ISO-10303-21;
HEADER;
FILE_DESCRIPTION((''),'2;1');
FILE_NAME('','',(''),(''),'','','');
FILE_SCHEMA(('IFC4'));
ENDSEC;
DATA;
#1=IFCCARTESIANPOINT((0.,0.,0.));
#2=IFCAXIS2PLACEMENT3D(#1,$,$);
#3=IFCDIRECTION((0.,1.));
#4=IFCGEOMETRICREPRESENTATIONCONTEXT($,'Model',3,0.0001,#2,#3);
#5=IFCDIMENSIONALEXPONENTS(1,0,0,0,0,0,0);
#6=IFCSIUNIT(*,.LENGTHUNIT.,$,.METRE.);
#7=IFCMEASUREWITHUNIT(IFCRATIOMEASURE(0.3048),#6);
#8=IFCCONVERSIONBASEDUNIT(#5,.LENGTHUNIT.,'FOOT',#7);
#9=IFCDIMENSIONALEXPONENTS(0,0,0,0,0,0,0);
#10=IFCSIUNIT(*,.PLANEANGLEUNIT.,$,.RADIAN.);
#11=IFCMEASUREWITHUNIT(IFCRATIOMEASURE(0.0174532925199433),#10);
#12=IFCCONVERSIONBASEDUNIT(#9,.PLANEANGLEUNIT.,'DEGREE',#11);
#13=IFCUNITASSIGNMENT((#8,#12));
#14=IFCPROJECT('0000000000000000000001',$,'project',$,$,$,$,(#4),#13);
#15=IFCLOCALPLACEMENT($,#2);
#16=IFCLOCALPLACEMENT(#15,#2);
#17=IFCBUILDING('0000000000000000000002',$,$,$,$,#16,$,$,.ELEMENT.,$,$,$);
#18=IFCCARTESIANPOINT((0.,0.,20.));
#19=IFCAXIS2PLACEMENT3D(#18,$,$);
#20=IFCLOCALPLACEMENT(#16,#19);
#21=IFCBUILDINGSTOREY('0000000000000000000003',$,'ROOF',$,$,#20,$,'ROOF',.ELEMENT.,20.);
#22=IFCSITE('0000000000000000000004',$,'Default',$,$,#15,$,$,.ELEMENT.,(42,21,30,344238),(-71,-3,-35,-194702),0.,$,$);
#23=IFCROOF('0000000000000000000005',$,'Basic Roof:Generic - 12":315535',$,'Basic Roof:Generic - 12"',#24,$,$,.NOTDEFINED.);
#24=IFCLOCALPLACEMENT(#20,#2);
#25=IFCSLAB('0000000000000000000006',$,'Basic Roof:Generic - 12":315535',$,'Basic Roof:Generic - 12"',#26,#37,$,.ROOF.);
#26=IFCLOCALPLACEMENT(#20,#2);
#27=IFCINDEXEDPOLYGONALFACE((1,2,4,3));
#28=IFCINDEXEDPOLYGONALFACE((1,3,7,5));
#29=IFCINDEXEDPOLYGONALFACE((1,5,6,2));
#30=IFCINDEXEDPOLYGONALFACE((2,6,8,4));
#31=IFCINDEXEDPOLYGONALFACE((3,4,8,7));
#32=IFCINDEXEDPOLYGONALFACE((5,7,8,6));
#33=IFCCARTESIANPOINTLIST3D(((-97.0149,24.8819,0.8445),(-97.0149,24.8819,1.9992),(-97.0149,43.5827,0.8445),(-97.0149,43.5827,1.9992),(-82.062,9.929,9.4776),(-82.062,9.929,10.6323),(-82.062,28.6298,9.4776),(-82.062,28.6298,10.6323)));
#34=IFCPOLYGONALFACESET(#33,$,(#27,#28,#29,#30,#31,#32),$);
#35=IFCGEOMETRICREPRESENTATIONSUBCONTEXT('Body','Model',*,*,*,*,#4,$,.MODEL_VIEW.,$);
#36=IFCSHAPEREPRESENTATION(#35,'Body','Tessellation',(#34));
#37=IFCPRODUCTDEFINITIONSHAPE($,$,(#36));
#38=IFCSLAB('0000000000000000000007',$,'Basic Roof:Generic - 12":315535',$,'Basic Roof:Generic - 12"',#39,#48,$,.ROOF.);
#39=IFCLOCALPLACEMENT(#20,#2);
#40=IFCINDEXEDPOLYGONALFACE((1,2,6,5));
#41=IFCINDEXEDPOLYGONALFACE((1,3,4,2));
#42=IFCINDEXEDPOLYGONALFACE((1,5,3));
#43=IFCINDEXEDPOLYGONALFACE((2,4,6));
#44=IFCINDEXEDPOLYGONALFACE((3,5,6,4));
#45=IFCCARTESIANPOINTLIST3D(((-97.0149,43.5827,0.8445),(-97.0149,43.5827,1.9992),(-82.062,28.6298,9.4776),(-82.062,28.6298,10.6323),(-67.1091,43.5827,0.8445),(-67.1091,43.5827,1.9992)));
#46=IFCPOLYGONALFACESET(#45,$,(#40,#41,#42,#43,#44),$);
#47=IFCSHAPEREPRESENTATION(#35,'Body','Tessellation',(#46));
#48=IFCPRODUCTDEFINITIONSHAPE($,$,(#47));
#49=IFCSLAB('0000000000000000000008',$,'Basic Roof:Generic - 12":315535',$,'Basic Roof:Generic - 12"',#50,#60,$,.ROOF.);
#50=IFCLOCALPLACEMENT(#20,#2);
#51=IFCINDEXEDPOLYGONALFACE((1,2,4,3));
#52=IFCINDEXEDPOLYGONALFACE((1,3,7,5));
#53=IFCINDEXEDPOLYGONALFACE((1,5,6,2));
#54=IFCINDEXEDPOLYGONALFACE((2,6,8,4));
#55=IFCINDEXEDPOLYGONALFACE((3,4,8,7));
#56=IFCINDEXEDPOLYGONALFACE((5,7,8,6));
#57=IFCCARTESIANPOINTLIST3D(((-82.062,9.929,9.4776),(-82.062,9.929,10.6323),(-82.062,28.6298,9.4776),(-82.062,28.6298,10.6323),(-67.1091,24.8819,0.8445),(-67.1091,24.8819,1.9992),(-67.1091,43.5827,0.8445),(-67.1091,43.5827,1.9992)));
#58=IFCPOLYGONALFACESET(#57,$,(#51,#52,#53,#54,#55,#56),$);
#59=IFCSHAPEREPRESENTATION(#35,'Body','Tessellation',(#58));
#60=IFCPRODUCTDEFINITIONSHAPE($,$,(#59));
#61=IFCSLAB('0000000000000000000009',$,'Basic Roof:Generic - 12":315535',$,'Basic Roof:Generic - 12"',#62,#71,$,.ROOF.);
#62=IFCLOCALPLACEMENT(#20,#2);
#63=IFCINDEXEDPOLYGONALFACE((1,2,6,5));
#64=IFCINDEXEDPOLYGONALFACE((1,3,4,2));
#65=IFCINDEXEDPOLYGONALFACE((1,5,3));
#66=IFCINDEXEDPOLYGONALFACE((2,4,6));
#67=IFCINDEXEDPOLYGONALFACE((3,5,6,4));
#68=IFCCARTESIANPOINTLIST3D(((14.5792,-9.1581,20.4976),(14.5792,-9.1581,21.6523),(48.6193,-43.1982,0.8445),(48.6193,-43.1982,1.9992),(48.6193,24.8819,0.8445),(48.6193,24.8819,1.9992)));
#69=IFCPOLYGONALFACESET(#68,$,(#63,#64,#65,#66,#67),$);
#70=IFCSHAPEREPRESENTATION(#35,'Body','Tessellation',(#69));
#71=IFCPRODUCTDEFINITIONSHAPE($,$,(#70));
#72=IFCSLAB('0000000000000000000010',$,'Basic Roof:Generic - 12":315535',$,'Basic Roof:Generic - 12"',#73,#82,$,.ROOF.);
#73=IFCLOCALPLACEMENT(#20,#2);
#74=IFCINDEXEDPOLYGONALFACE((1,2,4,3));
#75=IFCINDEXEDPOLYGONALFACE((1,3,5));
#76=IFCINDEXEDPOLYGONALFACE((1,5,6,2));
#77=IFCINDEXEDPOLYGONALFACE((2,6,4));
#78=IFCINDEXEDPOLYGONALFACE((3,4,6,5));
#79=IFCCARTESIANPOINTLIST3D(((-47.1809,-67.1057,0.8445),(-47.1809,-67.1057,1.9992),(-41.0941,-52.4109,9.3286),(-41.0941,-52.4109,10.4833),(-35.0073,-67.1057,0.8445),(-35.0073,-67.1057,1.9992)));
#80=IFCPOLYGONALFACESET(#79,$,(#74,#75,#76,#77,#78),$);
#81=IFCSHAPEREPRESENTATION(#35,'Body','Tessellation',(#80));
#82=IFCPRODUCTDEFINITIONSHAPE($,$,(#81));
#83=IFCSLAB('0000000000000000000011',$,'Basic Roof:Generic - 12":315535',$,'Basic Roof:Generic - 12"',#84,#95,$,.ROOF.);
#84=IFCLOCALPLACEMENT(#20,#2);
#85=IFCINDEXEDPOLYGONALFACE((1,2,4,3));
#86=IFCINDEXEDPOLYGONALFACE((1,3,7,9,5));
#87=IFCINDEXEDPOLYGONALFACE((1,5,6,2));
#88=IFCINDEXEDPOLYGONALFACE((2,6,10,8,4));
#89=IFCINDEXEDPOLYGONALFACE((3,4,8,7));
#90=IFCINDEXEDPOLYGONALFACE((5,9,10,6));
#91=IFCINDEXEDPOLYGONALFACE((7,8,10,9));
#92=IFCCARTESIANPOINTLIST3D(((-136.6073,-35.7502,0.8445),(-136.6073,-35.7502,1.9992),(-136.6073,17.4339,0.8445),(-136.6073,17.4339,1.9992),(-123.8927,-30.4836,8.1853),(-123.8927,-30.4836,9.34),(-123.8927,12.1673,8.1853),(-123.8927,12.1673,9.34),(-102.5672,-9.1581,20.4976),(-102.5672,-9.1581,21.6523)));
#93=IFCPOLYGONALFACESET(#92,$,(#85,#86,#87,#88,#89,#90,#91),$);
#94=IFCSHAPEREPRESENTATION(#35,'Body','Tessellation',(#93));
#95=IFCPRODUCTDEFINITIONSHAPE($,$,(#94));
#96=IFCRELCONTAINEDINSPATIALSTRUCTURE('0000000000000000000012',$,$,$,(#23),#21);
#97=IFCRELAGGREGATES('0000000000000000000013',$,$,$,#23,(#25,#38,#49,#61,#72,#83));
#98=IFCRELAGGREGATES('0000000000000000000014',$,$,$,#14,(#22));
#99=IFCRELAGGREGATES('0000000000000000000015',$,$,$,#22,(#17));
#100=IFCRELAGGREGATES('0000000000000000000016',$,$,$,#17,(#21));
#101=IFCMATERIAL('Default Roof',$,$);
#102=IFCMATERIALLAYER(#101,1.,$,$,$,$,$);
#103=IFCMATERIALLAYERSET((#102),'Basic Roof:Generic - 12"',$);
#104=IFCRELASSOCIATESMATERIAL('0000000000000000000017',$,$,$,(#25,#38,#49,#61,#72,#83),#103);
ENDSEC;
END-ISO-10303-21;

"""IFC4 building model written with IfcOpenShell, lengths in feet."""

from ifc_helpers import new_model, entity, si_unit, converted_unit, direction, frame, origin, place, context, subcontext, project, spatial, polyline, outline, extrude, material, layer, layer_set, element, aggregate, save


model = new_model("IFC4")

# Units and contexts
model_context = context("Model", 3, precision=0.0001, world=origin(), true_north=direction((0.0, 1.0)))
body_context = subcontext(model_context, "Body", "Model", "MODEL_VIEW")
ifc_project = project(units=[converted_unit("LENGTHUNIT", "FOOT", entity("IfcRatioMeasure", 0.3048), si_unit("LENGTHUNIT", "METRE"), dimensions=[1, 0, 0, 0, 0, 0, 0]), converted_unit("PLANEANGLEUNIT", "DEGREE", entity("IfcRatioMeasure", 0.0174532925199433), si_unit("PLANEANGLEUNIT", "RADIAN"), dimensions=[0, 0, 0, 0, 0, 0, 0])], contexts=[model_context])

# Site, building, storey
site_placement = place(None, origin())
site = spatial("IfcSite", under=ifc_project, at=site_placement, Name="Default", CompositionType="ELEMENT", RefLatitude=(42, 21, 30, 344238), RefLongitude=(-71, -3, -35, -194702), RefElevation=0.0)
building_placement = place(site_placement, origin())
building = spatial("IfcBuilding", under=site, at=building_placement, CompositionType="ELEMENT")
storey_placement = place(building_placement, frame((0.0, 0.0, 20.0)))
storey = spatial("IfcBuildingStorey", under=building, at=storey_placement, Name="ROOF", LongName="ROOF", CompositionType="ELEMENT", Elevation=20.0)

# Roof, slabs
roof_placement = place(storey_placement, frame((-136.6073, -67.1057, 0.8445)))
roof = element("IfcRoof", 1, at=roof_placement, inside=storey, Name="Basic Roof:Generic - 12\":315535", ObjectType="Basic Roof:Generic - 12\"", PredefinedType="NOTDEFINED")
ifc_material = material(Name="Default Roof")
ifc_layer = layer(ifc_material, 1.0)
ifc_layer_set = layer_set([ifc_layer], Name="Basic Roof:Generic - 12\"")
slab_1_placement = place(roof_placement, origin())
slab_1 = element("IfcSlab", 2, at=slab_1_placement, material=ifc_layer_set, Name="Basic Roof:Generic - 12\":315535", ObjectType="Basic Roof:Generic - 12\"", PredefinedType="ROOF", context=body_context, shape_type="SweptSolid", body=[
    extrude(outline(polyline([(-8.6331, 16.8269), (-8.6331, -1.8739), (8.6331, -16.8269), (8.6331, 1.8739), (-8.6331, 16.8269)])), frame((47.0689, 93.8616, 4.3165), z_axis=(-0.5, 0.0, 0.866025), x_axis=(0.866025, 0.0, 0.5)), (0.5, 0.0, 0.866025), 1.1547),
])
slab_2_placement = place(roof_placement, origin())
slab_2 = element("IfcSlab", 3, at=slab_2_placement, material=ifc_layer_set, Name="Basic Roof:Generic - 12\":315535", ObjectType="Basic Roof:Generic - 12\"", PredefinedType="ROOF", context=body_context, shape_type="SweptSolid", body=[
    extrude(outline(polyline([(14.9529, 8.6331), (-14.9529, 8.6331), (0.0, -8.6331), (14.9529, 8.6331)])), frame((54.5453, 103.212, 4.3165), z_axis=(0.0, 0.5, 0.866025), x_axis=(1.0, 0.0, 0.0)), (0.0, -0.5, 0.866025), 1.1547),
])
slab_3_placement = place(roof_placement, origin())
slab_3 = element("IfcSlab", 4, at=slab_3_placement, material=ifc_layer_set, Name="Basic Roof:Generic - 12\":315535", ObjectType="Basic Roof:Generic - 12\"", PredefinedType="ROOF", context=body_context, shape_type="SweptSolid", body=[
    extrude(outline(polyline([(8.6331, -1.8739), (8.6331, 16.8269), (-8.6331, 1.8739), (-8.6331, -16.8269), (8.6331, -1.8739)])), frame((62.0218, 93.8616, 4.3165), z_axis=(0.5, 0.0, 0.866025), x_axis=(0.866025, 0.0, -0.5)), (-0.5, 0.0, 0.866025), 1.1547),
])
slab_4_placement = place(roof_placement, origin())
slab_4 = element("IfcSlab", 5, at=slab_4_placement, material=ifc_layer_set, Name="Basic Roof:Generic - 12\":315535", ObjectType="Basic Roof:Generic - 12\"", PredefinedType="ROOF", context=body_context, shape_type="SweptSolid", body=[
    extrude(outline(polyline([(19.6531, -34.0401), (19.6531, 34.0401), (-19.6531, 0.0), (19.6531, -34.0401)])), frame((168.2066, 57.9476, 9.8265), z_axis=(0.5, 0.0, 0.866025), x_axis=(0.866025, 0.0, -0.5)), (-0.5, 0.0, 0.866025), 1.1547),
])
slab_5_placement = place(roof_placement, origin())
slab_5 = element("IfcSlab", 6, at=slab_5_placement, material=ifc_layer_set, Name="Basic Roof:Generic - 12\":315535", ObjectType="Basic Roof:Generic - 12\"", PredefinedType="ROOF", context=body_context, shape_type="SweptSolid", body=[
    extrude(outline(polyline([(-6.0868, -8.484), (6.0868, -8.484), (0.0, 8.484), (-6.0868, -8.484)])), frame((95.5132, 7.3474, 4.242), z_axis=(0.0, -0.5, 0.866025), x_axis=(1.0, 0.0, 0.0)), (0.0, 0.5, 0.866025), 1.1547),
])
slab_6_placement = place(roof_placement, origin())
slab_6 = element("IfcSlab", 7, at=slab_6_placement, material=ifc_layer_set, Name="Basic Roof:Generic - 12\":315535", ObjectType="Basic Roof:Generic - 12\"", PredefinedType="ROOF", context=body_context, shape_type="SweptSolid", body=[
    extrude(outline(polyline([(-19.6531, 26.592), (-19.6531, -26.592), (-4.9715, -21.3255), (19.6531, 0.0), (-4.9715, 21.3255), (-19.6531, 26.592)])), frame((17.02, 57.9476, 9.8265), z_axis=(-0.5, 0.0, 0.866025), x_axis=(0.866025, 0.0, 0.5)), (0.5, 0.0, 0.866025), 1.1547),
])
aggregate(roof, [slab_1, slab_2, slab_3, slab_4, slab_5, slab_6])

save(model, "model.ifc")
